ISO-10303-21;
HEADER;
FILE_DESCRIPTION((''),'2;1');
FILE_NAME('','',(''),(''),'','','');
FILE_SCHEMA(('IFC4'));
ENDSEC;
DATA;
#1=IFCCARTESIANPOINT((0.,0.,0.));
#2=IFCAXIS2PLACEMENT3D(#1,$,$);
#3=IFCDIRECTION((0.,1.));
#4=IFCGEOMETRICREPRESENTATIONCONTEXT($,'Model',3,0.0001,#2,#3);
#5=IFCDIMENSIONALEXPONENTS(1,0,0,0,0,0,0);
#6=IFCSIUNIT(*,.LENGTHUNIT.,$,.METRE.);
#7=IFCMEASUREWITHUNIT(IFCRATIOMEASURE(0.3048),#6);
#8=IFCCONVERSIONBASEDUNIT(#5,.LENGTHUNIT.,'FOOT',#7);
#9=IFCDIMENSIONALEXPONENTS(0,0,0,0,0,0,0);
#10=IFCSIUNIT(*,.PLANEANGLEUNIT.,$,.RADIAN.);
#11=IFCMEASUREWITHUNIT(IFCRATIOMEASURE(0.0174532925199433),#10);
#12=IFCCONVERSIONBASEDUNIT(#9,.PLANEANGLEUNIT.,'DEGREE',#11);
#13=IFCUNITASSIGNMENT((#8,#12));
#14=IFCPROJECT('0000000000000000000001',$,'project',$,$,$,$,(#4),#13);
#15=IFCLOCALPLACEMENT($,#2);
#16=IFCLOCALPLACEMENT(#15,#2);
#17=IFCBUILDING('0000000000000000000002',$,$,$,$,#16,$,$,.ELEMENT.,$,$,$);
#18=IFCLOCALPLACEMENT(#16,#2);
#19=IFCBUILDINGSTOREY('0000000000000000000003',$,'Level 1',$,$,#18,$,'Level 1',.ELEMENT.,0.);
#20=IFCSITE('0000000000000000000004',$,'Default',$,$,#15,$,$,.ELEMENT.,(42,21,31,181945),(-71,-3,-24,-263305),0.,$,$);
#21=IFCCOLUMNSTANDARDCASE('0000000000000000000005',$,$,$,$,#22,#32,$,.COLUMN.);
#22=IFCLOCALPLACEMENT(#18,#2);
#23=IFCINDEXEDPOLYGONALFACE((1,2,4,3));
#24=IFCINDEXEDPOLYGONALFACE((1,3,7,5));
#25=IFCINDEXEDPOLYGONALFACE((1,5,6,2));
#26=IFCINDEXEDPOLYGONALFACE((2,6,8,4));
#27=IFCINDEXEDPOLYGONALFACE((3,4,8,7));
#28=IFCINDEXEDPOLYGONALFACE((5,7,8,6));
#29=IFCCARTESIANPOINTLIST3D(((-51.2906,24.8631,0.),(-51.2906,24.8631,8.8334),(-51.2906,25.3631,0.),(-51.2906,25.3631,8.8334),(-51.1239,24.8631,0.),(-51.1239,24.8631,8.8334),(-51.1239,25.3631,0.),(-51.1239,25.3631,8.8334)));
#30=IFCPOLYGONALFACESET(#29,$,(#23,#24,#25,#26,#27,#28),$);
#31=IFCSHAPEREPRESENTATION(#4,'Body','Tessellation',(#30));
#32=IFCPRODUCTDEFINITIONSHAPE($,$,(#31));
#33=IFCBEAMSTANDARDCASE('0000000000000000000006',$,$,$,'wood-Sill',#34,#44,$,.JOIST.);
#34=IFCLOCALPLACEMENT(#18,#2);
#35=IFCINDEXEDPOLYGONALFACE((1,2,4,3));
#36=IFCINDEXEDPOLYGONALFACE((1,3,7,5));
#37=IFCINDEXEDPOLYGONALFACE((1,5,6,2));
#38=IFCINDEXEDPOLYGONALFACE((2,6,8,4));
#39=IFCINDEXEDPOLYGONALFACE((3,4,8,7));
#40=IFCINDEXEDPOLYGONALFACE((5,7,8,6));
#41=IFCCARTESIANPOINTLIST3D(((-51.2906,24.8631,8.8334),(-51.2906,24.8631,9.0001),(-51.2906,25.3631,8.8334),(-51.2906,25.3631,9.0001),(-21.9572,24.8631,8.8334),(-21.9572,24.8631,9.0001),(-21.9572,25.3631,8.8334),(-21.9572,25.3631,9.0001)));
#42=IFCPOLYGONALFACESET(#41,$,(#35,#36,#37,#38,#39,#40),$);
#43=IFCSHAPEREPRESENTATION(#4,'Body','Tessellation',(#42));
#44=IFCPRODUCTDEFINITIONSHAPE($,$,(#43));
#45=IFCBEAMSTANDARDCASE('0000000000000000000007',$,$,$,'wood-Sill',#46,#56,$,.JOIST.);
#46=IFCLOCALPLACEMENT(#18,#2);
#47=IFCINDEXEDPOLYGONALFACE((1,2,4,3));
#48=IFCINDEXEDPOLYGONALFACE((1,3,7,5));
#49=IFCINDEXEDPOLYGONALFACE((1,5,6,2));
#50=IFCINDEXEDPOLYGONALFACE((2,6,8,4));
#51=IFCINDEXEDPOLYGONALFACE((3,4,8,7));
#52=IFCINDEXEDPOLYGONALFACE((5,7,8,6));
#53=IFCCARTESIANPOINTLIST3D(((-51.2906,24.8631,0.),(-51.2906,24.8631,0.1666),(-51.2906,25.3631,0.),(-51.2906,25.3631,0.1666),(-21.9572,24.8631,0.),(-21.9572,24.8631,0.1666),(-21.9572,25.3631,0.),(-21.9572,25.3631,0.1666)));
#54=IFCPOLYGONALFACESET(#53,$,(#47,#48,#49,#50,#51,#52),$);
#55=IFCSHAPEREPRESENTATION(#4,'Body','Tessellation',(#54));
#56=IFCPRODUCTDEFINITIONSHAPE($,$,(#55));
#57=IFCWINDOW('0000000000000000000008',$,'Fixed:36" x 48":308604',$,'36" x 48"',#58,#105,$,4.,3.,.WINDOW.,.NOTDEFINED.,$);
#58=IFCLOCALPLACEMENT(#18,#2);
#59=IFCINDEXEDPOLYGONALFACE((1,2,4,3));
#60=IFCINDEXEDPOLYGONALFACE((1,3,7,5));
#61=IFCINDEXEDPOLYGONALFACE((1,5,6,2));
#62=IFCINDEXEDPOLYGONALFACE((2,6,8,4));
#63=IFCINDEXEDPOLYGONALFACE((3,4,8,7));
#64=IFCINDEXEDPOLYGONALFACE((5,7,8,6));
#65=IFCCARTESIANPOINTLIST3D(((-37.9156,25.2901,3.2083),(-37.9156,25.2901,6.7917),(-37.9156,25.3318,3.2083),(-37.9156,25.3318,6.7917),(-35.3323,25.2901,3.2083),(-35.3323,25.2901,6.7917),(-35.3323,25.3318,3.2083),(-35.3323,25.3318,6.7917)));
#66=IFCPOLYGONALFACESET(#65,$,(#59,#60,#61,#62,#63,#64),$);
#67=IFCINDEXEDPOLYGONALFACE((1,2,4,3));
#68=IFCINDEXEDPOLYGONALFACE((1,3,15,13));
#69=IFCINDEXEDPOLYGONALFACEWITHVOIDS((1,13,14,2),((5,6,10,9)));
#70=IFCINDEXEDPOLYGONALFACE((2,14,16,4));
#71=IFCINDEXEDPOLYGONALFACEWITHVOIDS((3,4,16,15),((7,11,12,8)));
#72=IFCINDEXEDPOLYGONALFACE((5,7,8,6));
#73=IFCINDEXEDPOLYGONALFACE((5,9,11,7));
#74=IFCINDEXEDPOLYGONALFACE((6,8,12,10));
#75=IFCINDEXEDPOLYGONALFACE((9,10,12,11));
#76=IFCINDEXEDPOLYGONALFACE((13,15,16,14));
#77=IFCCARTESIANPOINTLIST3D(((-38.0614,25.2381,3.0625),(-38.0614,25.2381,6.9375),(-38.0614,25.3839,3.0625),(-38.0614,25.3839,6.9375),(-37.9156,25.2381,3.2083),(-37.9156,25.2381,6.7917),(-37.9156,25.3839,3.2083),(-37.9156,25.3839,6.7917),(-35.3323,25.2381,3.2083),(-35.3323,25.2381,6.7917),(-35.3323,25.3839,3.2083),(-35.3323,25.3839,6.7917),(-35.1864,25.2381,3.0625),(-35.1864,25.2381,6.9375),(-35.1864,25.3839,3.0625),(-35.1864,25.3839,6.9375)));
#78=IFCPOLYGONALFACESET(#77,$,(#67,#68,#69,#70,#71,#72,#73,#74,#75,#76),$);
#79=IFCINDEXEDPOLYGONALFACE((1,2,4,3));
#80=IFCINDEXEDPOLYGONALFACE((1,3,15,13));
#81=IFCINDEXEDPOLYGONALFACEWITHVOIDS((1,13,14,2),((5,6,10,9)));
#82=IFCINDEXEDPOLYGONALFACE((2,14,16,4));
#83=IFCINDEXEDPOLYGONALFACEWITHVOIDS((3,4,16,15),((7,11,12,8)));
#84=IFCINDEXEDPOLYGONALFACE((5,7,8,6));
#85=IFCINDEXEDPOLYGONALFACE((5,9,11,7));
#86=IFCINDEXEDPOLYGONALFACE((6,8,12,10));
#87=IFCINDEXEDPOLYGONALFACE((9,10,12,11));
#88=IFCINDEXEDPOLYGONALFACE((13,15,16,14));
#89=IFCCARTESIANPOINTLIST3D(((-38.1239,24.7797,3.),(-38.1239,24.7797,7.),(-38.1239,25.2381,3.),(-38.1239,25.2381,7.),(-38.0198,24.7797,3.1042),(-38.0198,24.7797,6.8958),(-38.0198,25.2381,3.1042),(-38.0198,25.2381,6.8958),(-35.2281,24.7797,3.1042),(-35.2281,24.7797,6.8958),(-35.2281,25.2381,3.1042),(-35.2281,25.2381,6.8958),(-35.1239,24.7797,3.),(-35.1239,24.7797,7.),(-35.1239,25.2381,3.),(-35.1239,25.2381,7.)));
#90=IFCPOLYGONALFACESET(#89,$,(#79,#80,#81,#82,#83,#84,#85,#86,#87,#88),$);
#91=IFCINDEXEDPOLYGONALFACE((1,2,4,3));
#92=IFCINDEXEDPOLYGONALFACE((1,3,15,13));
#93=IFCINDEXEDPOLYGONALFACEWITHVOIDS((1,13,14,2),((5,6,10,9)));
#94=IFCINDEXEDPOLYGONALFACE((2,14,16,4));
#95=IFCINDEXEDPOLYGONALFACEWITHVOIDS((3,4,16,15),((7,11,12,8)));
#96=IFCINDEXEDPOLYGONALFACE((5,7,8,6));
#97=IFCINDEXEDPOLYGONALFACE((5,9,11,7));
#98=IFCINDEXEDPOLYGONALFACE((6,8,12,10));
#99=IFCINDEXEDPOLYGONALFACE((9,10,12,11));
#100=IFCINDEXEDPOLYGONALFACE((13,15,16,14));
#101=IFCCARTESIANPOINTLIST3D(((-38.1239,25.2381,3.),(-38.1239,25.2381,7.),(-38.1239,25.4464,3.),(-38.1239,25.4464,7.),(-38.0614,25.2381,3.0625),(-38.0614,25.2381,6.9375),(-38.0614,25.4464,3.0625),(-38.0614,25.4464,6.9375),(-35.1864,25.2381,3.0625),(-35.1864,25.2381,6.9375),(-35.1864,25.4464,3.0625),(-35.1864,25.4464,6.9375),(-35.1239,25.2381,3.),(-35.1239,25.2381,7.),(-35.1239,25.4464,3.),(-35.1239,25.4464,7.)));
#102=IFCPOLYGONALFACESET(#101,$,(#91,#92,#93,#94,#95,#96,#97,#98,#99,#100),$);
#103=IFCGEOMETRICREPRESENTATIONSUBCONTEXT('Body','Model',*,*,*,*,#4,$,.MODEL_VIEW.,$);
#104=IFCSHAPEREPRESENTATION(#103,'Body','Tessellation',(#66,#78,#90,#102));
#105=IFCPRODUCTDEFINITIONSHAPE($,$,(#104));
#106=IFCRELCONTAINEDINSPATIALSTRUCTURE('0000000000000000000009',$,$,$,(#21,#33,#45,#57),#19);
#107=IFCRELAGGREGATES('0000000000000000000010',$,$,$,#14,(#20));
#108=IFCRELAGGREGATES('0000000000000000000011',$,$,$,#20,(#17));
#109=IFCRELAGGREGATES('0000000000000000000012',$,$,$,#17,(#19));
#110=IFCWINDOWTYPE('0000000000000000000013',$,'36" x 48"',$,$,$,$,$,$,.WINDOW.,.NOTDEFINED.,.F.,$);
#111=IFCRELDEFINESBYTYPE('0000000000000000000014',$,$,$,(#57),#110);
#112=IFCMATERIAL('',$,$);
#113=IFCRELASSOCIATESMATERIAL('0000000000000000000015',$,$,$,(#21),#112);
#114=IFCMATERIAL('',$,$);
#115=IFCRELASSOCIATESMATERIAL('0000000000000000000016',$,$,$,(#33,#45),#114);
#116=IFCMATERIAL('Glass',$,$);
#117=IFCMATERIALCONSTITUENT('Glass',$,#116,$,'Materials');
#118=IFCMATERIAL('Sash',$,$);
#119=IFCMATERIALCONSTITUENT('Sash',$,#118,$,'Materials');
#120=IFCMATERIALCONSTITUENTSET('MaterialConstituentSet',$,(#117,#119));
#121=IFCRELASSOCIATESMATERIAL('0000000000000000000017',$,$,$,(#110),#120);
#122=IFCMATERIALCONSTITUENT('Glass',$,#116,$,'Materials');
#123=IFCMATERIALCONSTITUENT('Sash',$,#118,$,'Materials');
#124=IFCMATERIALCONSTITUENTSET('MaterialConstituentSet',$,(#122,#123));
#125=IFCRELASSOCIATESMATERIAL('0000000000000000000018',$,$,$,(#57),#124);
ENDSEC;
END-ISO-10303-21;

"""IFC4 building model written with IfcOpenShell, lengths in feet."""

from ifc_helpers import new_model, entity, si_unit, converted_unit, direction, frame, frame_2d, origin, origin_with_axes, place, context, subcontext, project, spatial, polyline, rectangle, outline, extrude, source, transform, mapped, material, constituent, constituent_set, type_object, type_shapes, element, save


model = new_model("IFC4")

# Units and contexts
model_context = context("Model", 3, precision=0.0001, world=origin(), true_north=direction((0.0, 1.0)))
body_context = subcontext(model_context, "Body", "Model", "MODEL_VIEW")
ifc_project = project(units=[converted_unit("LENGTHUNIT", "FOOT", entity("IfcRatioMeasure", 0.3048), si_unit("LENGTHUNIT", "METRE"), dimensions=[1, 0, 0, 0, 0, 0, 0]), converted_unit("PLANEANGLEUNIT", "DEGREE", entity("IfcRatioMeasure", 0.0174532925199433), si_unit("PLANEANGLEUNIT", "RADIAN"), dimensions=[0, 0, 0, 0, 0, 0, 0])], contexts=[model_context])

# Site, building, storey
site_placement = place(None, origin())
site = spatial("IfcSite", under=ifc_project, at=site_placement, Name="Default", CompositionType="ELEMENT", RefLatitude=(42, 21, 31, 181945), RefLongitude=(-71, -3, -24, -263305), RefElevation=0.0)
building_placement = place(site_placement, origin())
building = spatial("IfcBuilding", under=site, at=building_placement, CompositionType="ELEMENT")
storey_placement = place(building_placement, origin())
storey = spatial("IfcBuildingStorey", under=building, at=storey_placement, Name="Level 1", LongName="Level 1", CompositionType="ELEMENT", Elevation=0.0)

# Column
ifc_material_1 = material(Name="")
placement_1 = place(storey_placement, frame((-51.2906, 25.1131, 0.0)))
for number, where, z_axis, x_axis in (
    (1, (0.0833, 0.0, 0.0), (0.0, 0.0, 1.0), (1.0, 0.0, 0.0)),
):
    element("IfcColumnStandardCase", number, at=place(placement_1, frame(where, z_axis=z_axis, x_axis=x_axis)), inside=storey, material=ifc_material_1, PredefinedType="COLUMN", context=model_context, shape_type="SweptSolid", body=[
        extrude(rectangle(XDim=0.1667, YDim=0.5), origin(), (0.0, 0.0, 1.0), 8.8334),
    ])

# Beams
ifc_material_2 = material(Name="")
for number, where, z_axis, x_axis in (
    (2, (0.0, 0.0, 8.9167), (1.0, 0.0, 0.0), (0.0, 0.0, 1.0)),
    (3, (0.0, 0.0, 0.0833), (1.0, 0.0, 0.0), (0.0, 0.0, 1.0)),
):
    element("IfcBeamStandardCase", number, at=place(placement_1, frame(where, z_axis=z_axis, x_axis=x_axis)), inside=storey, material=ifc_material_2, ObjectType="wood-Sill", PredefinedType="JOIST", context=model_context, shape_type="SweptSolid", body=[
        extrude(rectangle(XDim=0.1667, YDim=0.5), origin_with_axes(), (0.0, 0.0, 1.0), 29.3334),
    ])

# Window
ifc_material_3 = material(Name="Glass")
ifc_constituent_1 = constituent(ifc_material_3, Name="Glass", Category="Materials")
ifc_material_4 = material(Name="Sash")
ifc_constituent_2 = constituent(ifc_material_4, Name="Sash", Category="Materials")
ifc_constituent_set_1 = constituent_set(constituents=[ifc_constituent_1, ifc_constituent_2], Name="MaterialConstituentSet")
ifc_constituent_3 = constituent(ifc_material_3, Name="Glass", Category="Materials")
ifc_constituent_4 = constituent(ifc_material_4, Name="Sash", Category="Materials")
ifc_constituent_set_2 = constituent_set(constituents=[ifc_constituent_3, ifc_constituent_4], Name="MaterialConstituentSet")
window_type = type_object("IfcWindowType", Name="36\" x 48\"", ParameterTakesPrecedence=False, PartitioningType="NOTDEFINED", PredefinedType="WINDOW", material=ifc_constituent_set_2)
shared_shape = source(origin(), body_context, "Body", "SweptSolid", [
    extrude(rectangle(XDim=0.0417, YDim=2.5833, at=frame_2d((0.0, 0.0), x_axis=(1.0, 0.0))), frame((1.5, 0.5312, 0.2083), z_axis=(0.0, 0.0, 1.0), x_axis=(0.0, 1.0, 0.0)), (0.0, 0.0, 1.0), 3.5833),
    extrude(outline(polyline([(-1.4375, -1.9375), (1.4375, -1.9375), (1.4375, 1.9375), (-1.4375, 1.9375), (-1.4375, -1.9375)]), holes=[polyline([(-1.2917, -1.7917), (-1.2917, 1.7917), (1.2917, 1.7917), (1.2917, -1.7917), (-1.2917, -1.7917)])]), frame((1.5, 0.4583, 2.0), z_axis=(0.0, 1.0, 0.0), x_axis=(1.0, 0.0, 0.0)), (0.0, 0.0, 1.0), 0.1458),
    extrude(outline(polyline([(-1.5, -2.0), (1.5, -2.0), (1.5, 2.0), (-1.5, 2.0), (-1.5, -2.0)]), holes=[polyline([(-1.3958, -1.8958), (-1.3958, 1.8958), (1.3958, 1.8958), (1.3958, -1.8958), (-1.3958, -1.8958)])]), frame((1.5, 0.0, 2.0), z_axis=(0.0, 1.0, 0.0), x_axis=(1.0, 0.0, 0.0)), (0.0, 0.0, 1.0), 0.4583),
    extrude(outline(polyline([(-2.0, -1.5), (2.0, -1.5), (2.0, 1.5), (-2.0, 1.5), (-2.0, -1.5)]), holes=[polyline([(-1.9375, -1.4375), (-1.9375, 1.4375), (1.9375, 1.4375), (1.9375, -1.4375), (-1.9375, -1.4375)])]), frame((1.5, 0.4583, 2.0), z_axis=(0.0, 1.0, 0.0), x_axis=(0.0, 0.0, -1.0)), (0.0, 0.0, 1.0), 0.2083),
])
type_shapes(window_type, [shared_shape])
placement_2 = place(placement_1, frame((13.1667, -0.3333, 3.0)))
window_placement = place(placement_2, origin())
element("IfcWindow", 4, at=window_placement, inside=storey, type_object=window_type, material=ifc_constituent_set_1, Name="Fixed:36\" x 48\":308604", ObjectType="36\" x 48\"", OverallHeight=4.0, OverallWidth=3.0, PartitioningType="NOTDEFINED", PredefinedType="WINDOW", context=body_context, shape_type="MappedRepresentation", body=[
    mapped(shared_shape, transform((0.0, 0.0, 0.0), scale=1.0)),
])

save(model, "model.ifc")
